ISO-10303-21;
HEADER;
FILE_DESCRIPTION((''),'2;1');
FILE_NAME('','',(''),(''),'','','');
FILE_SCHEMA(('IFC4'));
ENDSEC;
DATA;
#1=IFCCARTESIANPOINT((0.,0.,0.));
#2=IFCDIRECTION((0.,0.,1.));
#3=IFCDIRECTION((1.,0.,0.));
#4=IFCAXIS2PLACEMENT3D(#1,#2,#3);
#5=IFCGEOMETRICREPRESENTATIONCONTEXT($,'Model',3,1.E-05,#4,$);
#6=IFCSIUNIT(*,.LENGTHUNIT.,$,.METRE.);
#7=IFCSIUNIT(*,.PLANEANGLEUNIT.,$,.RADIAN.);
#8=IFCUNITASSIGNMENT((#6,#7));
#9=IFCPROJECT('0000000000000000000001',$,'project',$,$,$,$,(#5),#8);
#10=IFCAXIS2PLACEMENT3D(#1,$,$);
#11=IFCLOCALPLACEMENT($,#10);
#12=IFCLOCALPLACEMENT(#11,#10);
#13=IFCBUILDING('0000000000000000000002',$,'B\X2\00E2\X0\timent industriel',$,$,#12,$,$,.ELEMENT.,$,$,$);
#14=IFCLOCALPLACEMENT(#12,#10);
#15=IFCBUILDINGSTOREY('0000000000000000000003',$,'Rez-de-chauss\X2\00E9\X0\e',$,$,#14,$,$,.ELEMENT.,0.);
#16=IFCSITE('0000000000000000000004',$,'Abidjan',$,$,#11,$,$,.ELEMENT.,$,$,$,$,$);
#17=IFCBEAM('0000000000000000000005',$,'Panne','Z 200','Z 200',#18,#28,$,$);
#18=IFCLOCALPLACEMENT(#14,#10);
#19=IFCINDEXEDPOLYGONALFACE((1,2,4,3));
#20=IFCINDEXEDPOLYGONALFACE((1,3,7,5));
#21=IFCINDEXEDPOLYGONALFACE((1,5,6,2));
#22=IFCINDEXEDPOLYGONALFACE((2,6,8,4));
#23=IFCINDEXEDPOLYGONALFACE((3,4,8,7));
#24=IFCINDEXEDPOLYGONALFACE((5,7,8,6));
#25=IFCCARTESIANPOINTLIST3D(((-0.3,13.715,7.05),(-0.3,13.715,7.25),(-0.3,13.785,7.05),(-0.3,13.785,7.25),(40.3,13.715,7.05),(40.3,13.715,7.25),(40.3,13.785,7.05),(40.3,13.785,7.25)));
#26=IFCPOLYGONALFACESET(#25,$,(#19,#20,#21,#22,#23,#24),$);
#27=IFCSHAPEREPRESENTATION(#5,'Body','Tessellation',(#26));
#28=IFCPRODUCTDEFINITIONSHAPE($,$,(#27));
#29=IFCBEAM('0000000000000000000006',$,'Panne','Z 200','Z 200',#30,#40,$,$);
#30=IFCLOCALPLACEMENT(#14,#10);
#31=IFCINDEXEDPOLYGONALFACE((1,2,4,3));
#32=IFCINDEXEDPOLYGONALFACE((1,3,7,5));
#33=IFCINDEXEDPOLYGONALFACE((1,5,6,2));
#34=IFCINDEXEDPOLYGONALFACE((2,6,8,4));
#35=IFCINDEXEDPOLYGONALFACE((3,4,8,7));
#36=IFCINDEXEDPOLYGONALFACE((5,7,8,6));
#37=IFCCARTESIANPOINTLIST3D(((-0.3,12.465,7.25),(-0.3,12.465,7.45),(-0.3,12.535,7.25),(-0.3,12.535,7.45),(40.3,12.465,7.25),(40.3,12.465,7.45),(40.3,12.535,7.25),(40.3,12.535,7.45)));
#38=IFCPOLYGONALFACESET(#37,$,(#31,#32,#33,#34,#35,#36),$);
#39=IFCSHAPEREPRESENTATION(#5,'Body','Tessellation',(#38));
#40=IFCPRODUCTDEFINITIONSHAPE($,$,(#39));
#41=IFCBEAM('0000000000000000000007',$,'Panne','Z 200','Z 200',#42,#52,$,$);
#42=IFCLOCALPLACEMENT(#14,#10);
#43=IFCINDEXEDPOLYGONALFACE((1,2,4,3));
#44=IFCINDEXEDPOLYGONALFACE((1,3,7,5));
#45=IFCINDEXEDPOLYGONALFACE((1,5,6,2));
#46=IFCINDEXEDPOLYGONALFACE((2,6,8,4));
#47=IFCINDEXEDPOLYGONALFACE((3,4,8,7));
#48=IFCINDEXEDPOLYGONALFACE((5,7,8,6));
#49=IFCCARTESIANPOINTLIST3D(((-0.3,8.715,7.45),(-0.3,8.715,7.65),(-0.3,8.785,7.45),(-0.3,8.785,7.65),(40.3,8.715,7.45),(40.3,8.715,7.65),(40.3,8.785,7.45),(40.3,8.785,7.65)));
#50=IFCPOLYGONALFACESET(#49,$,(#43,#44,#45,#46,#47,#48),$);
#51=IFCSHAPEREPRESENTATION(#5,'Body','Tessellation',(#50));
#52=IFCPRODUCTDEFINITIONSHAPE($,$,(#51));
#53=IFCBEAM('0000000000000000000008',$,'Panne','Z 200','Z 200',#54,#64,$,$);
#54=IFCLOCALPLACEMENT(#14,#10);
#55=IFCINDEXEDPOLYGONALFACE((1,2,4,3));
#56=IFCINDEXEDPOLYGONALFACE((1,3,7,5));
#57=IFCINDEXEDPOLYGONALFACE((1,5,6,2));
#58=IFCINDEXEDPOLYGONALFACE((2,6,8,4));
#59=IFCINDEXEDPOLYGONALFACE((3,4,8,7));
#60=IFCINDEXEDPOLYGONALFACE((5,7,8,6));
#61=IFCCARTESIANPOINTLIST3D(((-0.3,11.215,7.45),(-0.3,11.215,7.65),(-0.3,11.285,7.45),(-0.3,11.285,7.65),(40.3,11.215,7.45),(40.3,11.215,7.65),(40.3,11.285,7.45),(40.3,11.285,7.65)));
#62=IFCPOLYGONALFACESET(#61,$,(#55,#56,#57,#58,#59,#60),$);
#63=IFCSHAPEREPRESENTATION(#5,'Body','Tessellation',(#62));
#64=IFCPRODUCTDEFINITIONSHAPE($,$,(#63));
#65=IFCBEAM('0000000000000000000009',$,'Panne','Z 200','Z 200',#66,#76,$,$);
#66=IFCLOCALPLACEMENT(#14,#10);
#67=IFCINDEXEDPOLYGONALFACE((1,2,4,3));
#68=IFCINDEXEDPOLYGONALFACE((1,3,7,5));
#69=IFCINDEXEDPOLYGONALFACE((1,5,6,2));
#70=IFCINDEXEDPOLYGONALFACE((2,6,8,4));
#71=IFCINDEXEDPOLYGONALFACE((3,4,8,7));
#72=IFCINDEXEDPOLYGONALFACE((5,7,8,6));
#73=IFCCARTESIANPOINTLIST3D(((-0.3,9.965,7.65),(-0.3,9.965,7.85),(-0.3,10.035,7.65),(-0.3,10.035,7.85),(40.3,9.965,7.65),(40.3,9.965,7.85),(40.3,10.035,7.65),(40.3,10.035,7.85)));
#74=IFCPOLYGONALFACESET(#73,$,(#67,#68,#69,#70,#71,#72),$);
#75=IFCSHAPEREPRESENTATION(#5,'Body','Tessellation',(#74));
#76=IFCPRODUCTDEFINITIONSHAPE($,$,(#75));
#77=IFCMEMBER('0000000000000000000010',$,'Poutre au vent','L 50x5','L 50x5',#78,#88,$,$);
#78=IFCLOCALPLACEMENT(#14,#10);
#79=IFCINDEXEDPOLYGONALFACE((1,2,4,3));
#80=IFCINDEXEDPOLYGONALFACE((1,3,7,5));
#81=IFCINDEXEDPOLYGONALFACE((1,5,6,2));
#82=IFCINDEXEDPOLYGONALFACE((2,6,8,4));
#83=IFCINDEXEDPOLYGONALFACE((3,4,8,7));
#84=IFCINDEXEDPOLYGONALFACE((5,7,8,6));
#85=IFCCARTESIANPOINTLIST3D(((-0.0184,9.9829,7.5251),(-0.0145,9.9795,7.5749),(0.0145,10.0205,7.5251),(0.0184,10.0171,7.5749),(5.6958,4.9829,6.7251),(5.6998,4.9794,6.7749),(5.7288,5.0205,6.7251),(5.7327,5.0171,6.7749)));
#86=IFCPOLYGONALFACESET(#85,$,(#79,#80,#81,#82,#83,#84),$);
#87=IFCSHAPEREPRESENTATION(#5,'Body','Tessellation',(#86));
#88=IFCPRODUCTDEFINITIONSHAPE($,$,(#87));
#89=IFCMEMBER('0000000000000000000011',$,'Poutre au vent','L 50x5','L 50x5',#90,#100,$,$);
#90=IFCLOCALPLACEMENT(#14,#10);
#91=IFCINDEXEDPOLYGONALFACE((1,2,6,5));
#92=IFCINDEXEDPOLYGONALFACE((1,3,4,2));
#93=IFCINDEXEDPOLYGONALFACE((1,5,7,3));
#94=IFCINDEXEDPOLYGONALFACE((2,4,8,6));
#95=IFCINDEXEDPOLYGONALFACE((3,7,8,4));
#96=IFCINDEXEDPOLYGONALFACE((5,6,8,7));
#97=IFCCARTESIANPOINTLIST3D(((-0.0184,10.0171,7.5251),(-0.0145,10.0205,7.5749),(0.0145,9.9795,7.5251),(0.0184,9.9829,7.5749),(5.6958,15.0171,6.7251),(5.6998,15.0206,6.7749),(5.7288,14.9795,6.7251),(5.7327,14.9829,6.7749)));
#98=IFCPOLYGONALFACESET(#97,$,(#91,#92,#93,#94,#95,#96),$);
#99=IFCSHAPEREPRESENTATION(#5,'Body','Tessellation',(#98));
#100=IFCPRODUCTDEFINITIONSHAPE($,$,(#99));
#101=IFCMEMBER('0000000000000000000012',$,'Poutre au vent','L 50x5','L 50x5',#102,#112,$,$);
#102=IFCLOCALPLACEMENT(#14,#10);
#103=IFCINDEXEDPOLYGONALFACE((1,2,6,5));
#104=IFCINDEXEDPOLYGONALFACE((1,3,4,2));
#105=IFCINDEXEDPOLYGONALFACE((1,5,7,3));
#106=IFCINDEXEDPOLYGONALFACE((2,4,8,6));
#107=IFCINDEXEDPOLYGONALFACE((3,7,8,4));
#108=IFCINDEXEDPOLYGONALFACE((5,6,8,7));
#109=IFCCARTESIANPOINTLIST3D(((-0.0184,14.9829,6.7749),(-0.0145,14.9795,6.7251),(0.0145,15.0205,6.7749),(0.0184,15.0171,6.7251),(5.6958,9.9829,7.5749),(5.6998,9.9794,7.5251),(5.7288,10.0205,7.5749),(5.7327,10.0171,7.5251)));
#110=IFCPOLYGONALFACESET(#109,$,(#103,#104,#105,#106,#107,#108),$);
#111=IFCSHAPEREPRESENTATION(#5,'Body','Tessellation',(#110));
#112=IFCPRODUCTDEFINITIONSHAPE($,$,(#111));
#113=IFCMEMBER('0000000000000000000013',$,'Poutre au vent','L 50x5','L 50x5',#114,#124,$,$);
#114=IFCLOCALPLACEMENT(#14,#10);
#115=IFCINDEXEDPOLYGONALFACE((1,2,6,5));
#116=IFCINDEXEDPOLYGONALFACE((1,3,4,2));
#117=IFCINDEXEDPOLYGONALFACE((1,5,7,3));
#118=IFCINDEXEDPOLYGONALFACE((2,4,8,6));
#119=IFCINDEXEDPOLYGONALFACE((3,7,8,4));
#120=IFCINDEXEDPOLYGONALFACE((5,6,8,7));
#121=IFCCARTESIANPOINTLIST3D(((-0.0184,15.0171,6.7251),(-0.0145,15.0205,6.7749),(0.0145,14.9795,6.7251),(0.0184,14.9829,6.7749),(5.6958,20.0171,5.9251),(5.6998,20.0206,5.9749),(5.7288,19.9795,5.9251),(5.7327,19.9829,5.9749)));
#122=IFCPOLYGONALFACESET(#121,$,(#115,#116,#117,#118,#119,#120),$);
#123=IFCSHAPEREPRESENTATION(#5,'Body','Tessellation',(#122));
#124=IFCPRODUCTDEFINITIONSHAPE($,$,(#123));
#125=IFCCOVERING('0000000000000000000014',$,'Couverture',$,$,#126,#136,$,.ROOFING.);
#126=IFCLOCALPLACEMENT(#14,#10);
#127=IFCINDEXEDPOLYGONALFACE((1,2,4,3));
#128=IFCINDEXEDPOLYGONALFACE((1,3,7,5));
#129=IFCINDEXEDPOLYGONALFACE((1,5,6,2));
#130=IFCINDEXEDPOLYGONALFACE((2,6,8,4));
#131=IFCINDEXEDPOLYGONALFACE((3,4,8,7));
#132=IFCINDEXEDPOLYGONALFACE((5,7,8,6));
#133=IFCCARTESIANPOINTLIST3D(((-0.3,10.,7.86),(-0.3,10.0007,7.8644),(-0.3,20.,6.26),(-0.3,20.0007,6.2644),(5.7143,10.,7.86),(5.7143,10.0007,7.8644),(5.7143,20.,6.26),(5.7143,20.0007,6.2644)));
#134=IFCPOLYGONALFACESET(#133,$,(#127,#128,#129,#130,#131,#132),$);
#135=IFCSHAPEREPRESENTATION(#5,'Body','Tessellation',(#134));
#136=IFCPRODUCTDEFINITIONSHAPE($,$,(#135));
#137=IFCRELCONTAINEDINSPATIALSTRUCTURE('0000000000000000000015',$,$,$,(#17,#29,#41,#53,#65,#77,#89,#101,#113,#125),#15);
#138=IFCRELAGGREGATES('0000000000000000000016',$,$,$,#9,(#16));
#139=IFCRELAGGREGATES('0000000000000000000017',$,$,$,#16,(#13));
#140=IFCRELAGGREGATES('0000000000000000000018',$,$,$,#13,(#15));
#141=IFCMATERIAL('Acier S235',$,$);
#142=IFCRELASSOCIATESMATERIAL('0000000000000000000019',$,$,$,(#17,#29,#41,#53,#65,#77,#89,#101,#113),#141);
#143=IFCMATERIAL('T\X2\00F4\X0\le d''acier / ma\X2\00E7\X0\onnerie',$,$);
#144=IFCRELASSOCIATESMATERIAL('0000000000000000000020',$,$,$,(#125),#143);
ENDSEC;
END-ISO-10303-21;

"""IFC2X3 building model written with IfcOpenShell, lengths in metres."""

from ifc_helpers import new_model, si_unit, frame, origin, origin_with_axes, origin_2d, place, context, project, spatial, polyline, rectangle, outline, extrude, material, element, save


model = new_model("IFC2X3")

# Units and contexts
model_context = context("Model", 3, precision=1e-05, world=origin_with_axes())
ifc_project = project(units=[si_unit("LENGTHUNIT", "METRE"), si_unit("PLANEANGLEUNIT", "RADIAN")], contexts=[model_context])

# Site, building, storey
site_placement = place(None, origin())
site = spatial("IfcSite", under=ifc_project, at=site_placement, Name="Abidjan", CompositionType="ELEMENT")
building_placement = place(site_placement, origin())
building = spatial("IfcBuilding", under=site, at=building_placement, Name="Bâtiment industriel", CompositionType="ELEMENT")
storey_placement = place(building_placement, origin())
storey = spatial("IfcBuildingStorey", under=building, at=storey_placement, Name="Rez-de-chaussée", CompositionType="ELEMENT", Elevation=0.0)

# Shared definitions
ifc_material_1 = material(Name="Acier S235")

# Beams
for number, where, z_axis, x_axis, name in (
    (1, (-0.3, 13.75, 7.15), (1.0, 0.0, 0.0), (0.0, 1.0, 0.0), "Panne"),
    (2, (-0.3, 12.5, 7.35), (1.0, 0.0, 0.0), (0.0, 1.0, 0.0), "Panne"),
    (3, (-0.3, 8.75, 7.55), (1.0, 0.0, 0.0), (0.0, 1.0, 0.0), "Panne"),
    (4, (-0.3, 11.25, 7.55), (1.0, 0.0, 0.0), (0.0, 1.0, 0.0), "Panne"),
    (5, (-0.3, 10.0, 7.75), (1.0, 0.0, 0.0), (0.0, 1.0, 0.0), "Panne"),
):
    element("IfcBeam", number, at=place(storey_placement, frame(where, z_axis=z_axis, x_axis=x_axis)), inside=storey, material=ifc_material_1, Name=name, Description="Z 200", ObjectType="Z 200", context=model_context, shape_type="SweptSolid", body=[
        extrude(rectangle(XDim=0.07, YDim=0.2, at=origin_2d()), origin(), (0.0, 0.0, 1.0), 40.6),
    ])

# Members
for number, where, z_axis, x_axis, name in (
    (6, (0.0, 10.0, 7.55), (0.74843, -0.65488, -0.10478), (0.07886, -0.069, 0.9945), "Poutre au vent"),
    (7, (0.0, 10.0, 7.55), (0.74843, 0.65488, -0.10478), (0.07886, 0.069, 0.9945), "Poutre au vent"),
    (8, (0.0, 15.0, 6.75), (0.74843, -0.65488, 0.10478), (-0.07886, 0.069, 0.9945), "Poutre au vent"),
    (9, (0.0, 15.0, 6.75), (0.74843, 0.65488, -0.10478), (0.07886, 0.069, 0.9945), "Poutre au vent"),
):
    element("IfcMember", number, at=place(storey_placement, frame(where, z_axis=z_axis, x_axis=x_axis)), inside=storey, material=ifc_material_1, Name=name, Description="L 50x5", ObjectType="L 50x5", context=model_context, shape_type="SweptSolid", body=[
        extrude(rectangle(XDim=0.05, YDim=0.05, at=origin_2d()), origin(), (0.0, 0.0, 1.0), 7.635),
    ])

# Covering
ifc_material_2 = material(Name="Tôle d'acier / maçonnerie")
covering_placement = place(storey_placement, frame((-0.3, 10.0, 7.86), z_axis=(0.0, 0.15799, 0.98744), x_axis=(1.0, 0.0, 0.0)))
element("IfcCovering", 10, at=covering_placement, inside=storey, material=ifc_material_2, Name="Couverture", PredefinedType="ROOFING", context=model_context, shape_type="SweptSolid", body=[
    extrude(outline(polyline([(0.0, 0.0), (6.0143, 0.0), (6.0143, 10.1272), (0.0, 10.1272), (0.0, 0.0)])), origin(), (0.0, 0.0, 1.0), 0.0045),
])

save(model, "model.ifc")
